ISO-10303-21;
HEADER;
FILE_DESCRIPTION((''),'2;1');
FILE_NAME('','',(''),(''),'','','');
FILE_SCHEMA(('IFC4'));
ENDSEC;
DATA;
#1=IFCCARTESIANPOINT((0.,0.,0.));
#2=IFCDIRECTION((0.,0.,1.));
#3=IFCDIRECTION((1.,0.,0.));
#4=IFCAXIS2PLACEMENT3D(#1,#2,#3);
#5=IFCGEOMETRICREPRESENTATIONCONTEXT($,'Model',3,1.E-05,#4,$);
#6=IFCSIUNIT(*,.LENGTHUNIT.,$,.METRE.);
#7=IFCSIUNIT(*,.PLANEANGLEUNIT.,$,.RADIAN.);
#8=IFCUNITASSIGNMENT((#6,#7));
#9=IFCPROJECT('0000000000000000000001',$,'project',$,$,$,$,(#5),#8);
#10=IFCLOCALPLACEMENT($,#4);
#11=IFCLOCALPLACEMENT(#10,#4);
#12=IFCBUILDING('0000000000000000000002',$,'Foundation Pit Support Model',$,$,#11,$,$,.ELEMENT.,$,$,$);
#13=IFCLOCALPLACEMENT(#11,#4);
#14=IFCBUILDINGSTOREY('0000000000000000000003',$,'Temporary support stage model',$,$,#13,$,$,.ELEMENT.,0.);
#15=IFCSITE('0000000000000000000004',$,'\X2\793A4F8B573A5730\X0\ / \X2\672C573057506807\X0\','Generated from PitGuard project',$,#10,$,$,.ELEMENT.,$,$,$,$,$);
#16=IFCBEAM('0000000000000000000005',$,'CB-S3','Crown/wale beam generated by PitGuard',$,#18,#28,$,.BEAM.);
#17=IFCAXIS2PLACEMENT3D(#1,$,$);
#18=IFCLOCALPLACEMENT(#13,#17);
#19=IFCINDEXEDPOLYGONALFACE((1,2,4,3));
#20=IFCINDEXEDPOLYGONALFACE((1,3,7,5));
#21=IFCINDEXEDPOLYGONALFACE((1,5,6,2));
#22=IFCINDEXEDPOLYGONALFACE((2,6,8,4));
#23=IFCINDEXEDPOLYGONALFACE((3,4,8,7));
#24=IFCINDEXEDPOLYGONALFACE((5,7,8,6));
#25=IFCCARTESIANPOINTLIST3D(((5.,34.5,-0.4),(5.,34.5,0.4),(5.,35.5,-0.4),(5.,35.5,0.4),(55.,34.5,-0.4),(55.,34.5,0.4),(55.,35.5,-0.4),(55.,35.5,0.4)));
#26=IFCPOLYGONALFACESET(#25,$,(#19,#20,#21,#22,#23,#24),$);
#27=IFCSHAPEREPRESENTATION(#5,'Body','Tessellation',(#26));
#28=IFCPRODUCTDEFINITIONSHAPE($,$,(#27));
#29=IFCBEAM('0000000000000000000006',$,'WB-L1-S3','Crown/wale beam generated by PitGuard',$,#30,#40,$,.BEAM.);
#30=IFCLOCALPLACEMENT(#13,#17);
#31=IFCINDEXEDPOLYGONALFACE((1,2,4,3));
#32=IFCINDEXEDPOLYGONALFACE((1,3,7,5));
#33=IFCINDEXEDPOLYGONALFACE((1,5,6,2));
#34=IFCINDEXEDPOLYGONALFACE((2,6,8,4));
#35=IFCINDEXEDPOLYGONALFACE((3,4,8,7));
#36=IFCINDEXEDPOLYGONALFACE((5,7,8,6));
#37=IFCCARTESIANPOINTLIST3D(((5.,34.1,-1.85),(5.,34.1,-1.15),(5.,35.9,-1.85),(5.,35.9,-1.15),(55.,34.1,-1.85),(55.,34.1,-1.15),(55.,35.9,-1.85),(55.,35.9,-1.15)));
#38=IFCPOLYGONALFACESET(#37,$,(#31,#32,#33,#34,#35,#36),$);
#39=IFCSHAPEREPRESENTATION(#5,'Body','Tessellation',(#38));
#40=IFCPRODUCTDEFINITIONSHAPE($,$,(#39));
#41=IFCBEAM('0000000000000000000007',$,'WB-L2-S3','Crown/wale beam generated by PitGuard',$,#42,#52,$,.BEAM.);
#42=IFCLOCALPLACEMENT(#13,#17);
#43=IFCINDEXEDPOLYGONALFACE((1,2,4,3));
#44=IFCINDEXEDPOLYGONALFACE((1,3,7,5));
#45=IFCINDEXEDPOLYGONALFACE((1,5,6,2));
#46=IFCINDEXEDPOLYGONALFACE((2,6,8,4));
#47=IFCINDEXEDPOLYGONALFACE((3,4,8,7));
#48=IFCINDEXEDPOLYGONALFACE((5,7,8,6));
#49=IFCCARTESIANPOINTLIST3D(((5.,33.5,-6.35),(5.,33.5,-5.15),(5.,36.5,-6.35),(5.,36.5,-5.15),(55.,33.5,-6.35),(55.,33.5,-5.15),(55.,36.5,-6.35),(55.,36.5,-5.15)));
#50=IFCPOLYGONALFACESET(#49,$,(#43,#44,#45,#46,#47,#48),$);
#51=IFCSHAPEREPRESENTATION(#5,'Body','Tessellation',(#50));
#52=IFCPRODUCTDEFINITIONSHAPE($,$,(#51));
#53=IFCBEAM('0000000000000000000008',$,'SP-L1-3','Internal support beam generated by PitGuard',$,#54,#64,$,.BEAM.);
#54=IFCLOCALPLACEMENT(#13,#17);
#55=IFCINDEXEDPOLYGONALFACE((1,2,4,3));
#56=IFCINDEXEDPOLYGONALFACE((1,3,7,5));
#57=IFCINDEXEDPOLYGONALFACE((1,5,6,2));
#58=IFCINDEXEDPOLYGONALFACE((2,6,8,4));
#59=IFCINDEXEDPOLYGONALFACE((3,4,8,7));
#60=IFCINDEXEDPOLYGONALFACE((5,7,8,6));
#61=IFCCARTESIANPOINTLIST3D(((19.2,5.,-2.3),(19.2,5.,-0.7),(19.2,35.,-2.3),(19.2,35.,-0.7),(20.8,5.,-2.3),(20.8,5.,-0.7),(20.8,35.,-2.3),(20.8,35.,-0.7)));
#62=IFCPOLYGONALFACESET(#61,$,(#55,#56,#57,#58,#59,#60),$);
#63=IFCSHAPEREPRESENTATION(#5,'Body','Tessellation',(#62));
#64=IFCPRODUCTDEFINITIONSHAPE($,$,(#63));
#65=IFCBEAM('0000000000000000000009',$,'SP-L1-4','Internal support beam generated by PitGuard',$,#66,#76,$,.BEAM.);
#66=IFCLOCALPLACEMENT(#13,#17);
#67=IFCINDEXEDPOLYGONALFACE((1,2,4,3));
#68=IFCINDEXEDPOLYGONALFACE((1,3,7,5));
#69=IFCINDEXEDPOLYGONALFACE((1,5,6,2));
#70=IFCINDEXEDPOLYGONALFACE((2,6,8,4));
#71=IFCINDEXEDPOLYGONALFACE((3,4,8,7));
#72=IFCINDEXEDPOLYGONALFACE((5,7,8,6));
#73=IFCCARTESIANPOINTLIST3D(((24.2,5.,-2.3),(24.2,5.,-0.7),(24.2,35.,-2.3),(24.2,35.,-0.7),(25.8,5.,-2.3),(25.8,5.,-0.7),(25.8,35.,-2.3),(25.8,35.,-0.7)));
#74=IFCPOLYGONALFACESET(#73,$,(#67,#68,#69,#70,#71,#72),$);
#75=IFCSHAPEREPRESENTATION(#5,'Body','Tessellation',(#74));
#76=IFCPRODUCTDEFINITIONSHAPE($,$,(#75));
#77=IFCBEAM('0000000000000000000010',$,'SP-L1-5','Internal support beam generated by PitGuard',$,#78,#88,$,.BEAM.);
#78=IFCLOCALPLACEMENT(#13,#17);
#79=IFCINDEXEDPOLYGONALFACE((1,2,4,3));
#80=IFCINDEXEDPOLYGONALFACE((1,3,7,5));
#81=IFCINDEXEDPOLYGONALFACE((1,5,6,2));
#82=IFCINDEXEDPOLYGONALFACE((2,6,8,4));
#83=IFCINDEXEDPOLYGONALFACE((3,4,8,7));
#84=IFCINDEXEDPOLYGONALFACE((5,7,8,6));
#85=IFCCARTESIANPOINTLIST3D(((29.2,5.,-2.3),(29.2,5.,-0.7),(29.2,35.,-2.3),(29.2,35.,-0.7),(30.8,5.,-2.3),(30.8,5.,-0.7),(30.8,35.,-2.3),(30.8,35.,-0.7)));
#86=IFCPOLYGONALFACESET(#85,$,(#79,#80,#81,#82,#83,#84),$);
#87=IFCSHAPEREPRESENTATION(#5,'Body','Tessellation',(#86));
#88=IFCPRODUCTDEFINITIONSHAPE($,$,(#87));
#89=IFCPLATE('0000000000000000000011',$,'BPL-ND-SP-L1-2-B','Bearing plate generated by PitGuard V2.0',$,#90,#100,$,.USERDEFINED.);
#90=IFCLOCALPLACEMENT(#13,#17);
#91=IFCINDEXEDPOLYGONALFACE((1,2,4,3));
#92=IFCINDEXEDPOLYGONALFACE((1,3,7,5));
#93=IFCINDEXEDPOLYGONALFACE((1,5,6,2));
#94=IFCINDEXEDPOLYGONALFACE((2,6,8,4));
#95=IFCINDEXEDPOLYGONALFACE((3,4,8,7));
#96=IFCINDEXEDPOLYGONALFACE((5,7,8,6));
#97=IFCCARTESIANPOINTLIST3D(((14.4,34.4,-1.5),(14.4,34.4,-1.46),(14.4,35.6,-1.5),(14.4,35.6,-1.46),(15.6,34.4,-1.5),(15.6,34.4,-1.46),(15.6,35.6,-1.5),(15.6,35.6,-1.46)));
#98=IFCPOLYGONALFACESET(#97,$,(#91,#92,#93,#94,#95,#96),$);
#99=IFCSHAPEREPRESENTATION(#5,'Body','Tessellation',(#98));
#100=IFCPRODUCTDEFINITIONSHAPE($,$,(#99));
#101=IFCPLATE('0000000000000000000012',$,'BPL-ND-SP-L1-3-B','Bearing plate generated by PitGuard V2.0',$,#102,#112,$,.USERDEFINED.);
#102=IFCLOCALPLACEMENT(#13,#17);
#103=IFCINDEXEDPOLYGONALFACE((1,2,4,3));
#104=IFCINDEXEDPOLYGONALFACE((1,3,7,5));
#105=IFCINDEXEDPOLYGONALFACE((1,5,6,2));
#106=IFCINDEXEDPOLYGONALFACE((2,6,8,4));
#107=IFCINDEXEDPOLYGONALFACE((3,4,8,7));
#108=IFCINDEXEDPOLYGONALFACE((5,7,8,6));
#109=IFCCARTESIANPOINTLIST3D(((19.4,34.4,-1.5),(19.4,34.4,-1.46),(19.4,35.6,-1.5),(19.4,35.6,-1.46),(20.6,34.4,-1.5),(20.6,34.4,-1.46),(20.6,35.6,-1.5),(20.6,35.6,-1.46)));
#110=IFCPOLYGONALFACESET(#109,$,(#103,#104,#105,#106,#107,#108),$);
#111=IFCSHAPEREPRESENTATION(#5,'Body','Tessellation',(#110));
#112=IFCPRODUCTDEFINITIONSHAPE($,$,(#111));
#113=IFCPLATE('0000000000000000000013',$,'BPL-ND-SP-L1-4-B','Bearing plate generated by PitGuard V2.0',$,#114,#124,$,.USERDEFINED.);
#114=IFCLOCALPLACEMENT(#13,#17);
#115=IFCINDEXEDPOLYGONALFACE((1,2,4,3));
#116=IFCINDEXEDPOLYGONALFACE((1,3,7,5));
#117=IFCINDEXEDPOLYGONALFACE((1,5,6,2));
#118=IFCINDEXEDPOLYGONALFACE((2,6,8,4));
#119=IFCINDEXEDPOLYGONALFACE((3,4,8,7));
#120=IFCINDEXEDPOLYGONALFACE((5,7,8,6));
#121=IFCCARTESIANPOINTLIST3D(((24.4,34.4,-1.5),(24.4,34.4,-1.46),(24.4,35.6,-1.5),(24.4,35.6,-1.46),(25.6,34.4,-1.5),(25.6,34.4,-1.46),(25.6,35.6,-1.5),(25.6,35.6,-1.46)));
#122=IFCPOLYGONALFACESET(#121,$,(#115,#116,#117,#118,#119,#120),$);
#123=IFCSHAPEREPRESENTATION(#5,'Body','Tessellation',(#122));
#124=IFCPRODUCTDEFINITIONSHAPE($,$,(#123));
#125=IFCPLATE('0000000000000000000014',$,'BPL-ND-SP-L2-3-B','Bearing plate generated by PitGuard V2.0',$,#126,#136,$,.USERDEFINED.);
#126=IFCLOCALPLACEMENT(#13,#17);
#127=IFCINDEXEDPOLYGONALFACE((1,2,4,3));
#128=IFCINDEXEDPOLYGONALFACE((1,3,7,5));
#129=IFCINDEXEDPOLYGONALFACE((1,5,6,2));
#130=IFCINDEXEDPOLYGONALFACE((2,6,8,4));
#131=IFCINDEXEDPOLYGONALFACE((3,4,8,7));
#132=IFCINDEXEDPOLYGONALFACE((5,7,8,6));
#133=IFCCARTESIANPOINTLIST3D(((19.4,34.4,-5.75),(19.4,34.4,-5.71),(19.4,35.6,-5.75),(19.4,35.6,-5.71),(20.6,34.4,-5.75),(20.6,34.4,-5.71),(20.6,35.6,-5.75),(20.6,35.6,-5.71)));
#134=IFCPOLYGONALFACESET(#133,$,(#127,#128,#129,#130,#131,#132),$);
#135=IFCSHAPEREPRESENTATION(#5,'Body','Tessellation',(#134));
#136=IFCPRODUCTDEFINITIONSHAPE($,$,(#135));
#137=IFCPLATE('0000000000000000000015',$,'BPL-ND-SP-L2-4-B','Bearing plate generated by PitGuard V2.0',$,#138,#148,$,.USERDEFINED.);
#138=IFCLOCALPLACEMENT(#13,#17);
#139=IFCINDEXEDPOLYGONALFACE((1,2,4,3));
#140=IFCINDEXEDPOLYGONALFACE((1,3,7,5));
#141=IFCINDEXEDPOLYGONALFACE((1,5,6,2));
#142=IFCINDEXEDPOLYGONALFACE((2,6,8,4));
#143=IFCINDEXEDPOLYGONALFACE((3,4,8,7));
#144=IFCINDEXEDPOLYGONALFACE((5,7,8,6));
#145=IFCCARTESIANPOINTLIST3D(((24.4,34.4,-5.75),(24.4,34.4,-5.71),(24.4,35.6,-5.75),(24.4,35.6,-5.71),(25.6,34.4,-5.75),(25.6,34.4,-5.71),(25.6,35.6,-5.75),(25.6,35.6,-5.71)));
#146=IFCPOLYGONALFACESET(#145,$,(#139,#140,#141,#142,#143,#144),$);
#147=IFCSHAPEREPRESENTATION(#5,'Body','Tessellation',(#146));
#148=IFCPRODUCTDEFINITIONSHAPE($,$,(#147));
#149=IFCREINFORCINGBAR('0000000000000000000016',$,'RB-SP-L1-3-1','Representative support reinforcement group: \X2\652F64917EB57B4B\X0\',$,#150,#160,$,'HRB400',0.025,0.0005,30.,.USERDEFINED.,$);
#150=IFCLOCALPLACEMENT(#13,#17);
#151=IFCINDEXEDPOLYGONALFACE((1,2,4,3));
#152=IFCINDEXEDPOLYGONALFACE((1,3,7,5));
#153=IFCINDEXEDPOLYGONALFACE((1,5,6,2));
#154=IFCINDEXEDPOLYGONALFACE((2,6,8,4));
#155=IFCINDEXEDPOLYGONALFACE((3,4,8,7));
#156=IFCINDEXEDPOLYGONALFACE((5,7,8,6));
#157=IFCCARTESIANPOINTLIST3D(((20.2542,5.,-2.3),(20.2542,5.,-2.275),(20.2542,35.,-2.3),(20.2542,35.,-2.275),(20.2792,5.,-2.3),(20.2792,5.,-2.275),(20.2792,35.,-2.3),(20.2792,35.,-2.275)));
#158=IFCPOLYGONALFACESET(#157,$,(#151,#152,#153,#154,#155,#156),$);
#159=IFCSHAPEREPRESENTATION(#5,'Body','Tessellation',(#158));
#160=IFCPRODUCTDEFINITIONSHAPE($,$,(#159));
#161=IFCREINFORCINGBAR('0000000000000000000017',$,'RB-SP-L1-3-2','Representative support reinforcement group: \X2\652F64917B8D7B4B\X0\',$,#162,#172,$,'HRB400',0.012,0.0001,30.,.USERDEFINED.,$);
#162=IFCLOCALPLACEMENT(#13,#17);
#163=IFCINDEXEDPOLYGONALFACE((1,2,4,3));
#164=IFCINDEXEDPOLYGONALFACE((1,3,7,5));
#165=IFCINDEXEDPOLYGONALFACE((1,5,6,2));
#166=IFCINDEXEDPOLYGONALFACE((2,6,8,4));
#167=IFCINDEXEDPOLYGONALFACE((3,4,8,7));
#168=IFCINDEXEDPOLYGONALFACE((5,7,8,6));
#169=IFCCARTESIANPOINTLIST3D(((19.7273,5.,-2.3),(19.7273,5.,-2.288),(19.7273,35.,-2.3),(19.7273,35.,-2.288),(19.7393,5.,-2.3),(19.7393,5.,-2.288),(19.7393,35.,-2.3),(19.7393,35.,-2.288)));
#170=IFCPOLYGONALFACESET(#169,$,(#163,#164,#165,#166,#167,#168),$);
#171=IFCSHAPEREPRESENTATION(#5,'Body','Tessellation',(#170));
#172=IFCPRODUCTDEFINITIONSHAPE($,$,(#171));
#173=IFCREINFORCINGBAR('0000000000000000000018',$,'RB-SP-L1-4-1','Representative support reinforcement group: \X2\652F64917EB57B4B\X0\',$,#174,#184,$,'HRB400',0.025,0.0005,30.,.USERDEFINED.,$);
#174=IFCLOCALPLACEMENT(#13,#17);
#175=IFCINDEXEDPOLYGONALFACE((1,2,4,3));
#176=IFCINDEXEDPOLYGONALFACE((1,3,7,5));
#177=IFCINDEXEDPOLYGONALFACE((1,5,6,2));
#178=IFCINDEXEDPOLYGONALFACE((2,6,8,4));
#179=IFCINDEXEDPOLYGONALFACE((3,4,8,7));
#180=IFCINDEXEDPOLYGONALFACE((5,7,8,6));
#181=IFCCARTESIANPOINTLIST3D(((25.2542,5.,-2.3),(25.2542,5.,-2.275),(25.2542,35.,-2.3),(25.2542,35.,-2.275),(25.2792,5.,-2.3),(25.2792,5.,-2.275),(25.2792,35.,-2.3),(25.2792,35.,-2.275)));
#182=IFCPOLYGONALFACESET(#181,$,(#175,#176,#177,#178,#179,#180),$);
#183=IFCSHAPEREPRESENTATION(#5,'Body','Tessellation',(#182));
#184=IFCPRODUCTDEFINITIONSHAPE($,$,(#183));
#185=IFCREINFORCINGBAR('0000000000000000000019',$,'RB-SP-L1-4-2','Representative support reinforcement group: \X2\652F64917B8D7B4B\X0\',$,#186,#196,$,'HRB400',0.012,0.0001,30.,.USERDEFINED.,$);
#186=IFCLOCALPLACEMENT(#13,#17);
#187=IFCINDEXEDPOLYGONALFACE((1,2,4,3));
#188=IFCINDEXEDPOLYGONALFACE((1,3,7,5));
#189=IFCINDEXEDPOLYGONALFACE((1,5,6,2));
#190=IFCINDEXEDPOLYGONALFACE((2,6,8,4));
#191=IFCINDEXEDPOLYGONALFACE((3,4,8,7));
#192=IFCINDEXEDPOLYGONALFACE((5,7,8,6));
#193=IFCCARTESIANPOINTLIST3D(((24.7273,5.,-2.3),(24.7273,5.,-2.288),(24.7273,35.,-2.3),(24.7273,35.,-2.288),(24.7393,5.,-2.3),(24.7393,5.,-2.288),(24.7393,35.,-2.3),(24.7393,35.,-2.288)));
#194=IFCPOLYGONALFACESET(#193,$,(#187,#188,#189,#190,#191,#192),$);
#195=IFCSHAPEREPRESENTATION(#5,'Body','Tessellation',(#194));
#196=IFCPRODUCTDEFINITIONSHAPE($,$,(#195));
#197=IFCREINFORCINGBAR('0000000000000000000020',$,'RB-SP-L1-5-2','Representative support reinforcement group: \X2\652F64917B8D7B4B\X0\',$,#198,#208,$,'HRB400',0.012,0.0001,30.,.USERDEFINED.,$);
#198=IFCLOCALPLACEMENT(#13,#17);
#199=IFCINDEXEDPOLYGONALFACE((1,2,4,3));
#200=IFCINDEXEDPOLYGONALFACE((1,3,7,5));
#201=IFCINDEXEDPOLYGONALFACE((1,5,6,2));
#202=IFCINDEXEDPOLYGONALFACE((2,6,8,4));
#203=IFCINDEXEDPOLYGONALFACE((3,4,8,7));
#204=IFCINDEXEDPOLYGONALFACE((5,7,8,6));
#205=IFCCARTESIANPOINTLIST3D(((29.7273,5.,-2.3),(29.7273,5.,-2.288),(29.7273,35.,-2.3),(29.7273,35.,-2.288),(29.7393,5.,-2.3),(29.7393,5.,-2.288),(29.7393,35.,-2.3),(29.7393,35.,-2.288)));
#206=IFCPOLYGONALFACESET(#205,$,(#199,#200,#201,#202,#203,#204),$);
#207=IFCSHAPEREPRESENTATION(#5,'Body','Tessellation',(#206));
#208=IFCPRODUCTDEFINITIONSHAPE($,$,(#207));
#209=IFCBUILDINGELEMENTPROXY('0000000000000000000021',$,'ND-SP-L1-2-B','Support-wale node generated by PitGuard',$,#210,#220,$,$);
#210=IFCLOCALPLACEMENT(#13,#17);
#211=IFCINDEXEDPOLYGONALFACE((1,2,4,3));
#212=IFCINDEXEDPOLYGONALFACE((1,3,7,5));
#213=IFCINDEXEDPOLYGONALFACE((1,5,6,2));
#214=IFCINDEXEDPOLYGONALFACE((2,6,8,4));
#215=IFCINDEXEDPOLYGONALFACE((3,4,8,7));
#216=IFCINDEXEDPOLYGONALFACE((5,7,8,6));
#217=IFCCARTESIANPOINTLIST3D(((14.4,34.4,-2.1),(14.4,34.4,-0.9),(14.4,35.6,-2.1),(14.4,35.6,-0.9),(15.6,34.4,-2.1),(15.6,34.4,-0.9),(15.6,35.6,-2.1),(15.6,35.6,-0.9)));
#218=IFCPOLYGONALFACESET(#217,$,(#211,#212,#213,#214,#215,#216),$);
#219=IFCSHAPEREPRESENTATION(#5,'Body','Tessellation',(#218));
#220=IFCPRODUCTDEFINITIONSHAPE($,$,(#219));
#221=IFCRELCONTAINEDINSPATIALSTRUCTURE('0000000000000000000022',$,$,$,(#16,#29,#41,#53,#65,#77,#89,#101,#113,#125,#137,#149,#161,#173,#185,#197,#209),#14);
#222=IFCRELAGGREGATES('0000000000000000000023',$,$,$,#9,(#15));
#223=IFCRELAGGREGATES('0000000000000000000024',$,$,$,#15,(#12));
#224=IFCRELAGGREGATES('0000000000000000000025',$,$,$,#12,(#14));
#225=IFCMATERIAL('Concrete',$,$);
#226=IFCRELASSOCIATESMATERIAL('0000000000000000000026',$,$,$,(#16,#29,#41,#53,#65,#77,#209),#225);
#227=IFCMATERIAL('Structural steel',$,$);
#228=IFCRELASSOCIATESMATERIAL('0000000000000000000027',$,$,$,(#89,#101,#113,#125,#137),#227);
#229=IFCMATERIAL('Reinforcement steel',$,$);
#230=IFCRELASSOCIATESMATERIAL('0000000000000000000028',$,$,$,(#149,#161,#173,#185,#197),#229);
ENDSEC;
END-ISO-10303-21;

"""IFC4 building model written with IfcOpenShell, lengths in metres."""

from ifc_helpers import new_model, si_unit, frame, origin_with_axes, origin_2d, place, context, project, spatial, rectangle, extrude, material, element, save


model = new_model("IFC4")

# Units and contexts
model_context = context("Model", 3, precision=1e-05, world=origin_with_axes())
ifc_project = project(units=[si_unit("LENGTHUNIT", "METRE"), si_unit("PLANEANGLEUNIT", "RADIAN")], contexts=[model_context])

# Site, building, storey
site_placement = place(None, origin_with_axes())
site = spatial("IfcSite", under=ifc_project, at=site_placement, Name="示例场地 / 本地坐标", Description="Generated from PitGuard project", CompositionType="ELEMENT")
building_placement = place(site_placement, origin_with_axes())
building = spatial("IfcBuilding", under=site, at=building_placement, Name="Foundation Pit Support Model", CompositionType="ELEMENT")
storey_placement = place(building_placement, origin_with_axes())
storey = spatial("IfcBuildingStorey", under=building, at=storey_placement, Name="Temporary support stage model", CompositionType="ELEMENT", Elevation=0.0)

# Beams
ifc_material_1 = material(Name="Concrete")
beam_1_placement = place(storey_placement, frame((30.0, 35.0, -0.4), z_axis=(0.0, 0.0, 1.0), x_axis=(-1.0, 0.0, 0.0)))
element("IfcBeam", 1, at=beam_1_placement, inside=storey, material=ifc_material_1, Name="CB-S3", Description="Crown/wale beam generated by PitGuard", PredefinedType="BEAM", context=model_context, shape_type="SweptSolid", body=[
    extrude(rectangle(XDim=50.0, YDim=1.0, at=origin_2d()), origin_with_axes(), (0.0, 0.0, 1.0), 0.8),
])
beam_2_placement = place(storey_placement, frame((30.0, 35.0, -1.85), z_axis=(0.0, 0.0, 1.0), x_axis=(-1.0, 0.0, 0.0)))
element("IfcBeam", 2, at=beam_2_placement, inside=storey, material=ifc_material_1, Name="WB-L1-S3", Description="Crown/wale beam generated by PitGuard", PredefinedType="BEAM", context=model_context, shape_type="SweptSolid", body=[
    extrude(rectangle(XDim=50.0, YDim=1.8, at=origin_2d()), origin_with_axes(), (0.0, 0.0, 1.0), 0.7),
])
beam_3_placement = place(storey_placement, frame((30.0, 35.0, -6.35), z_axis=(0.0, 0.0, 1.0), x_axis=(-1.0, 0.0, 0.0)))
element("IfcBeam", 3, at=beam_3_placement, inside=storey, material=ifc_material_1, Name="WB-L2-S3", Description="Crown/wale beam generated by PitGuard", PredefinedType="BEAM", context=model_context, shape_type="SweptSolid", body=[
    extrude(rectangle(XDim=50.0, YDim=3.0, at=origin_2d()), origin_with_axes(), (0.0, 0.0, 1.0), 1.2),
])
for number, where, z_axis, x_axis, name in (
    (4, (20.0, 20.0, -2.3), (0.0, 0.0, 1.0), (0.0, 1.0, 0.0), "SP-L1-3"),
    (5, (25.0, 20.0, -2.3), (0.0, 0.0, 1.0), (0.0, 1.0, 0.0), "SP-L1-4"),
    (6, (30.0, 20.0, -2.3), (0.0, 0.0, 1.0), (0.0, 1.0, 0.0), "SP-L1-5"),
):
    element("IfcBeam", number, at=place(storey_placement, frame(where, z_axis=z_axis, x_axis=x_axis)), inside=storey, material=ifc_material_1, Name=name, Description="Internal support beam generated by PitGuard", PredefinedType="BEAM", context=model_context, shape_type="SweptSolid", body=[
        extrude(rectangle(XDim=30.0, YDim=1.6, at=origin_2d()), origin_with_axes(), (0.0, 0.0, 1.0), 1.6),
    ])

# Plates
ifc_material_2 = material(Name="Structural steel")
for number, where, z_axis, x_axis, name in (
    (7, (15.0, 35.0, -1.5), (0.0, 0.0, 1.0), (1.0, 0.0, 0.0), "BPL-ND-SP-L1-2-B"),
    (8, (20.0, 35.0, -1.5), (0.0, 0.0, 1.0), (1.0, 0.0, 0.0), "BPL-ND-SP-L1-3-B"),
    (9, (25.0, 35.0, -1.5), (0.0, 0.0, 1.0), (1.0, 0.0, 0.0), "BPL-ND-SP-L1-4-B"),
    (10, (20.0, 35.0, -5.75), (0.0, 0.0, 1.0), (1.0, 0.0, 0.0), "BPL-ND-SP-L2-3-B"),
    (11, (25.0, 35.0, -5.75), (0.0, 0.0, 1.0), (1.0, 0.0, 0.0), "BPL-ND-SP-L2-4-B"),
):
    element("IfcPlate", number, at=place(storey_placement, frame(where, z_axis=z_axis, x_axis=x_axis)), inside=storey, material=ifc_material_2, Name=name, Description="Bearing plate generated by PitGuard V2.0", PredefinedType="USERDEFINED", context=model_context, shape_type="SweptSolid", body=[
        extrude(rectangle(XDim=1.2, YDim=1.2, at=origin_2d()), origin_with_axes(), (0.0, 0.0, 1.0), 0.04),
    ])

# Reinforcing bars
ifc_material_3 = material(Name="Reinforcement steel")
reinforcing_bar_1_placement = place(storey_placement, frame((20.2667, 20.0, -2.3), z_axis=(0.0, 0.0, 1.0), x_axis=(0.0, 1.0, 0.0)))
element("IfcReinforcingBar", 12, at=reinforcing_bar_1_placement, inside=storey, material=ifc_material_3, Name="RB-SP-L1-3-1", Description="Representative support reinforcement group: 支撑纵筋", SteelGrade="HRB400", BarLength=30.0, CrossSectionArea=0.0005, NominalDiameter=0.025, PredefinedType="USERDEFINED", context=model_context, shape_type="SweptSolid", body=[
    extrude(rectangle(XDim=30.0, YDim=0.025, at=origin_2d()), origin_with_axes(), (0.0, 0.0, 1.0), 0.025),
])
reinforcing_bar_2_placement = place(storey_placement, frame((19.7333, 20.0, -2.3), z_axis=(0.0, 0.0, 1.0), x_axis=(0.0, 1.0, 0.0)))
element("IfcReinforcingBar", 13, at=reinforcing_bar_2_placement, inside=storey, material=ifc_material_3, Name="RB-SP-L1-3-2", Description="Representative support reinforcement group: 支撑箍筋", SteelGrade="HRB400", BarLength=30.0, CrossSectionArea=0.0001, NominalDiameter=0.012, PredefinedType="USERDEFINED", context=model_context, shape_type="SweptSolid", body=[
    extrude(rectangle(XDim=30.0, YDim=0.012, at=origin_2d()), origin_with_axes(), (0.0, 0.0, 1.0), 0.012),
])
reinforcing_bar_3_placement = place(storey_placement, frame((25.2667, 20.0, -2.3), z_axis=(0.0, 0.0, 1.0), x_axis=(0.0, 1.0, 0.0)))
element("IfcReinforcingBar", 14, at=reinforcing_bar_3_placement, inside=storey, material=ifc_material_3, Name="RB-SP-L1-4-1", Description="Representative support reinforcement group: 支撑纵筋", SteelGrade="HRB400", BarLength=30.0, CrossSectionArea=0.0005, NominalDiameter=0.025, PredefinedType="USERDEFINED", context=model_context, shape_type="SweptSolid", body=[
    extrude(rectangle(XDim=30.0, YDim=0.025, at=origin_2d()), origin_with_axes(), (0.0, 0.0, 1.0), 0.025),
])
for number, where, z_axis, x_axis, name in (
    (15, (24.7333, 20.0, -2.3), (0.0, 0.0, 1.0), (0.0, 1.0, 0.0), "RB-SP-L1-4-2"),
    (16, (29.7333, 20.0, -2.3), (0.0, 0.0, 1.0), (0.0, 1.0, 0.0), "RB-SP-L1-5-2"),
):
    element("IfcReinforcingBar", number, at=place(storey_placement, frame(where, z_axis=z_axis, x_axis=x_axis)), inside=storey, material=ifc_material_3, Name=name, Description="Representative support reinforcement group: 支撑箍筋", SteelGrade="HRB400", BarLength=30.0, CrossSectionArea=0.0001, NominalDiameter=0.012, PredefinedType="USERDEFINED", context=model_context, shape_type="SweptSolid", body=[
        extrude(rectangle(XDim=30.0, YDim=0.012, at=origin_2d()), origin_with_axes(), (0.0, 0.0, 1.0), 0.012),
    ])

# Building element proxy
proxy_1_placement = place(storey_placement, frame((15.0, 35.0, -2.1), z_axis=(0.0, 0.0, 1.0), x_axis=(1.0, 0.0, 0.0)))
element("IfcBuildingElementProxy", 17, at=proxy_1_placement, inside=storey, material=ifc_material_1, Name="ND-SP-L1-2-B", Description="Support-wale node generated by PitGuard", context=model_context, shape_type="SweptSolid", body=[
    extrude(rectangle(XDim=1.2, YDim=1.2, at=origin_2d()), origin_with_axes(), (0.0, 0.0, 1.0), 1.2),
])

save(model, "model.ifc")
